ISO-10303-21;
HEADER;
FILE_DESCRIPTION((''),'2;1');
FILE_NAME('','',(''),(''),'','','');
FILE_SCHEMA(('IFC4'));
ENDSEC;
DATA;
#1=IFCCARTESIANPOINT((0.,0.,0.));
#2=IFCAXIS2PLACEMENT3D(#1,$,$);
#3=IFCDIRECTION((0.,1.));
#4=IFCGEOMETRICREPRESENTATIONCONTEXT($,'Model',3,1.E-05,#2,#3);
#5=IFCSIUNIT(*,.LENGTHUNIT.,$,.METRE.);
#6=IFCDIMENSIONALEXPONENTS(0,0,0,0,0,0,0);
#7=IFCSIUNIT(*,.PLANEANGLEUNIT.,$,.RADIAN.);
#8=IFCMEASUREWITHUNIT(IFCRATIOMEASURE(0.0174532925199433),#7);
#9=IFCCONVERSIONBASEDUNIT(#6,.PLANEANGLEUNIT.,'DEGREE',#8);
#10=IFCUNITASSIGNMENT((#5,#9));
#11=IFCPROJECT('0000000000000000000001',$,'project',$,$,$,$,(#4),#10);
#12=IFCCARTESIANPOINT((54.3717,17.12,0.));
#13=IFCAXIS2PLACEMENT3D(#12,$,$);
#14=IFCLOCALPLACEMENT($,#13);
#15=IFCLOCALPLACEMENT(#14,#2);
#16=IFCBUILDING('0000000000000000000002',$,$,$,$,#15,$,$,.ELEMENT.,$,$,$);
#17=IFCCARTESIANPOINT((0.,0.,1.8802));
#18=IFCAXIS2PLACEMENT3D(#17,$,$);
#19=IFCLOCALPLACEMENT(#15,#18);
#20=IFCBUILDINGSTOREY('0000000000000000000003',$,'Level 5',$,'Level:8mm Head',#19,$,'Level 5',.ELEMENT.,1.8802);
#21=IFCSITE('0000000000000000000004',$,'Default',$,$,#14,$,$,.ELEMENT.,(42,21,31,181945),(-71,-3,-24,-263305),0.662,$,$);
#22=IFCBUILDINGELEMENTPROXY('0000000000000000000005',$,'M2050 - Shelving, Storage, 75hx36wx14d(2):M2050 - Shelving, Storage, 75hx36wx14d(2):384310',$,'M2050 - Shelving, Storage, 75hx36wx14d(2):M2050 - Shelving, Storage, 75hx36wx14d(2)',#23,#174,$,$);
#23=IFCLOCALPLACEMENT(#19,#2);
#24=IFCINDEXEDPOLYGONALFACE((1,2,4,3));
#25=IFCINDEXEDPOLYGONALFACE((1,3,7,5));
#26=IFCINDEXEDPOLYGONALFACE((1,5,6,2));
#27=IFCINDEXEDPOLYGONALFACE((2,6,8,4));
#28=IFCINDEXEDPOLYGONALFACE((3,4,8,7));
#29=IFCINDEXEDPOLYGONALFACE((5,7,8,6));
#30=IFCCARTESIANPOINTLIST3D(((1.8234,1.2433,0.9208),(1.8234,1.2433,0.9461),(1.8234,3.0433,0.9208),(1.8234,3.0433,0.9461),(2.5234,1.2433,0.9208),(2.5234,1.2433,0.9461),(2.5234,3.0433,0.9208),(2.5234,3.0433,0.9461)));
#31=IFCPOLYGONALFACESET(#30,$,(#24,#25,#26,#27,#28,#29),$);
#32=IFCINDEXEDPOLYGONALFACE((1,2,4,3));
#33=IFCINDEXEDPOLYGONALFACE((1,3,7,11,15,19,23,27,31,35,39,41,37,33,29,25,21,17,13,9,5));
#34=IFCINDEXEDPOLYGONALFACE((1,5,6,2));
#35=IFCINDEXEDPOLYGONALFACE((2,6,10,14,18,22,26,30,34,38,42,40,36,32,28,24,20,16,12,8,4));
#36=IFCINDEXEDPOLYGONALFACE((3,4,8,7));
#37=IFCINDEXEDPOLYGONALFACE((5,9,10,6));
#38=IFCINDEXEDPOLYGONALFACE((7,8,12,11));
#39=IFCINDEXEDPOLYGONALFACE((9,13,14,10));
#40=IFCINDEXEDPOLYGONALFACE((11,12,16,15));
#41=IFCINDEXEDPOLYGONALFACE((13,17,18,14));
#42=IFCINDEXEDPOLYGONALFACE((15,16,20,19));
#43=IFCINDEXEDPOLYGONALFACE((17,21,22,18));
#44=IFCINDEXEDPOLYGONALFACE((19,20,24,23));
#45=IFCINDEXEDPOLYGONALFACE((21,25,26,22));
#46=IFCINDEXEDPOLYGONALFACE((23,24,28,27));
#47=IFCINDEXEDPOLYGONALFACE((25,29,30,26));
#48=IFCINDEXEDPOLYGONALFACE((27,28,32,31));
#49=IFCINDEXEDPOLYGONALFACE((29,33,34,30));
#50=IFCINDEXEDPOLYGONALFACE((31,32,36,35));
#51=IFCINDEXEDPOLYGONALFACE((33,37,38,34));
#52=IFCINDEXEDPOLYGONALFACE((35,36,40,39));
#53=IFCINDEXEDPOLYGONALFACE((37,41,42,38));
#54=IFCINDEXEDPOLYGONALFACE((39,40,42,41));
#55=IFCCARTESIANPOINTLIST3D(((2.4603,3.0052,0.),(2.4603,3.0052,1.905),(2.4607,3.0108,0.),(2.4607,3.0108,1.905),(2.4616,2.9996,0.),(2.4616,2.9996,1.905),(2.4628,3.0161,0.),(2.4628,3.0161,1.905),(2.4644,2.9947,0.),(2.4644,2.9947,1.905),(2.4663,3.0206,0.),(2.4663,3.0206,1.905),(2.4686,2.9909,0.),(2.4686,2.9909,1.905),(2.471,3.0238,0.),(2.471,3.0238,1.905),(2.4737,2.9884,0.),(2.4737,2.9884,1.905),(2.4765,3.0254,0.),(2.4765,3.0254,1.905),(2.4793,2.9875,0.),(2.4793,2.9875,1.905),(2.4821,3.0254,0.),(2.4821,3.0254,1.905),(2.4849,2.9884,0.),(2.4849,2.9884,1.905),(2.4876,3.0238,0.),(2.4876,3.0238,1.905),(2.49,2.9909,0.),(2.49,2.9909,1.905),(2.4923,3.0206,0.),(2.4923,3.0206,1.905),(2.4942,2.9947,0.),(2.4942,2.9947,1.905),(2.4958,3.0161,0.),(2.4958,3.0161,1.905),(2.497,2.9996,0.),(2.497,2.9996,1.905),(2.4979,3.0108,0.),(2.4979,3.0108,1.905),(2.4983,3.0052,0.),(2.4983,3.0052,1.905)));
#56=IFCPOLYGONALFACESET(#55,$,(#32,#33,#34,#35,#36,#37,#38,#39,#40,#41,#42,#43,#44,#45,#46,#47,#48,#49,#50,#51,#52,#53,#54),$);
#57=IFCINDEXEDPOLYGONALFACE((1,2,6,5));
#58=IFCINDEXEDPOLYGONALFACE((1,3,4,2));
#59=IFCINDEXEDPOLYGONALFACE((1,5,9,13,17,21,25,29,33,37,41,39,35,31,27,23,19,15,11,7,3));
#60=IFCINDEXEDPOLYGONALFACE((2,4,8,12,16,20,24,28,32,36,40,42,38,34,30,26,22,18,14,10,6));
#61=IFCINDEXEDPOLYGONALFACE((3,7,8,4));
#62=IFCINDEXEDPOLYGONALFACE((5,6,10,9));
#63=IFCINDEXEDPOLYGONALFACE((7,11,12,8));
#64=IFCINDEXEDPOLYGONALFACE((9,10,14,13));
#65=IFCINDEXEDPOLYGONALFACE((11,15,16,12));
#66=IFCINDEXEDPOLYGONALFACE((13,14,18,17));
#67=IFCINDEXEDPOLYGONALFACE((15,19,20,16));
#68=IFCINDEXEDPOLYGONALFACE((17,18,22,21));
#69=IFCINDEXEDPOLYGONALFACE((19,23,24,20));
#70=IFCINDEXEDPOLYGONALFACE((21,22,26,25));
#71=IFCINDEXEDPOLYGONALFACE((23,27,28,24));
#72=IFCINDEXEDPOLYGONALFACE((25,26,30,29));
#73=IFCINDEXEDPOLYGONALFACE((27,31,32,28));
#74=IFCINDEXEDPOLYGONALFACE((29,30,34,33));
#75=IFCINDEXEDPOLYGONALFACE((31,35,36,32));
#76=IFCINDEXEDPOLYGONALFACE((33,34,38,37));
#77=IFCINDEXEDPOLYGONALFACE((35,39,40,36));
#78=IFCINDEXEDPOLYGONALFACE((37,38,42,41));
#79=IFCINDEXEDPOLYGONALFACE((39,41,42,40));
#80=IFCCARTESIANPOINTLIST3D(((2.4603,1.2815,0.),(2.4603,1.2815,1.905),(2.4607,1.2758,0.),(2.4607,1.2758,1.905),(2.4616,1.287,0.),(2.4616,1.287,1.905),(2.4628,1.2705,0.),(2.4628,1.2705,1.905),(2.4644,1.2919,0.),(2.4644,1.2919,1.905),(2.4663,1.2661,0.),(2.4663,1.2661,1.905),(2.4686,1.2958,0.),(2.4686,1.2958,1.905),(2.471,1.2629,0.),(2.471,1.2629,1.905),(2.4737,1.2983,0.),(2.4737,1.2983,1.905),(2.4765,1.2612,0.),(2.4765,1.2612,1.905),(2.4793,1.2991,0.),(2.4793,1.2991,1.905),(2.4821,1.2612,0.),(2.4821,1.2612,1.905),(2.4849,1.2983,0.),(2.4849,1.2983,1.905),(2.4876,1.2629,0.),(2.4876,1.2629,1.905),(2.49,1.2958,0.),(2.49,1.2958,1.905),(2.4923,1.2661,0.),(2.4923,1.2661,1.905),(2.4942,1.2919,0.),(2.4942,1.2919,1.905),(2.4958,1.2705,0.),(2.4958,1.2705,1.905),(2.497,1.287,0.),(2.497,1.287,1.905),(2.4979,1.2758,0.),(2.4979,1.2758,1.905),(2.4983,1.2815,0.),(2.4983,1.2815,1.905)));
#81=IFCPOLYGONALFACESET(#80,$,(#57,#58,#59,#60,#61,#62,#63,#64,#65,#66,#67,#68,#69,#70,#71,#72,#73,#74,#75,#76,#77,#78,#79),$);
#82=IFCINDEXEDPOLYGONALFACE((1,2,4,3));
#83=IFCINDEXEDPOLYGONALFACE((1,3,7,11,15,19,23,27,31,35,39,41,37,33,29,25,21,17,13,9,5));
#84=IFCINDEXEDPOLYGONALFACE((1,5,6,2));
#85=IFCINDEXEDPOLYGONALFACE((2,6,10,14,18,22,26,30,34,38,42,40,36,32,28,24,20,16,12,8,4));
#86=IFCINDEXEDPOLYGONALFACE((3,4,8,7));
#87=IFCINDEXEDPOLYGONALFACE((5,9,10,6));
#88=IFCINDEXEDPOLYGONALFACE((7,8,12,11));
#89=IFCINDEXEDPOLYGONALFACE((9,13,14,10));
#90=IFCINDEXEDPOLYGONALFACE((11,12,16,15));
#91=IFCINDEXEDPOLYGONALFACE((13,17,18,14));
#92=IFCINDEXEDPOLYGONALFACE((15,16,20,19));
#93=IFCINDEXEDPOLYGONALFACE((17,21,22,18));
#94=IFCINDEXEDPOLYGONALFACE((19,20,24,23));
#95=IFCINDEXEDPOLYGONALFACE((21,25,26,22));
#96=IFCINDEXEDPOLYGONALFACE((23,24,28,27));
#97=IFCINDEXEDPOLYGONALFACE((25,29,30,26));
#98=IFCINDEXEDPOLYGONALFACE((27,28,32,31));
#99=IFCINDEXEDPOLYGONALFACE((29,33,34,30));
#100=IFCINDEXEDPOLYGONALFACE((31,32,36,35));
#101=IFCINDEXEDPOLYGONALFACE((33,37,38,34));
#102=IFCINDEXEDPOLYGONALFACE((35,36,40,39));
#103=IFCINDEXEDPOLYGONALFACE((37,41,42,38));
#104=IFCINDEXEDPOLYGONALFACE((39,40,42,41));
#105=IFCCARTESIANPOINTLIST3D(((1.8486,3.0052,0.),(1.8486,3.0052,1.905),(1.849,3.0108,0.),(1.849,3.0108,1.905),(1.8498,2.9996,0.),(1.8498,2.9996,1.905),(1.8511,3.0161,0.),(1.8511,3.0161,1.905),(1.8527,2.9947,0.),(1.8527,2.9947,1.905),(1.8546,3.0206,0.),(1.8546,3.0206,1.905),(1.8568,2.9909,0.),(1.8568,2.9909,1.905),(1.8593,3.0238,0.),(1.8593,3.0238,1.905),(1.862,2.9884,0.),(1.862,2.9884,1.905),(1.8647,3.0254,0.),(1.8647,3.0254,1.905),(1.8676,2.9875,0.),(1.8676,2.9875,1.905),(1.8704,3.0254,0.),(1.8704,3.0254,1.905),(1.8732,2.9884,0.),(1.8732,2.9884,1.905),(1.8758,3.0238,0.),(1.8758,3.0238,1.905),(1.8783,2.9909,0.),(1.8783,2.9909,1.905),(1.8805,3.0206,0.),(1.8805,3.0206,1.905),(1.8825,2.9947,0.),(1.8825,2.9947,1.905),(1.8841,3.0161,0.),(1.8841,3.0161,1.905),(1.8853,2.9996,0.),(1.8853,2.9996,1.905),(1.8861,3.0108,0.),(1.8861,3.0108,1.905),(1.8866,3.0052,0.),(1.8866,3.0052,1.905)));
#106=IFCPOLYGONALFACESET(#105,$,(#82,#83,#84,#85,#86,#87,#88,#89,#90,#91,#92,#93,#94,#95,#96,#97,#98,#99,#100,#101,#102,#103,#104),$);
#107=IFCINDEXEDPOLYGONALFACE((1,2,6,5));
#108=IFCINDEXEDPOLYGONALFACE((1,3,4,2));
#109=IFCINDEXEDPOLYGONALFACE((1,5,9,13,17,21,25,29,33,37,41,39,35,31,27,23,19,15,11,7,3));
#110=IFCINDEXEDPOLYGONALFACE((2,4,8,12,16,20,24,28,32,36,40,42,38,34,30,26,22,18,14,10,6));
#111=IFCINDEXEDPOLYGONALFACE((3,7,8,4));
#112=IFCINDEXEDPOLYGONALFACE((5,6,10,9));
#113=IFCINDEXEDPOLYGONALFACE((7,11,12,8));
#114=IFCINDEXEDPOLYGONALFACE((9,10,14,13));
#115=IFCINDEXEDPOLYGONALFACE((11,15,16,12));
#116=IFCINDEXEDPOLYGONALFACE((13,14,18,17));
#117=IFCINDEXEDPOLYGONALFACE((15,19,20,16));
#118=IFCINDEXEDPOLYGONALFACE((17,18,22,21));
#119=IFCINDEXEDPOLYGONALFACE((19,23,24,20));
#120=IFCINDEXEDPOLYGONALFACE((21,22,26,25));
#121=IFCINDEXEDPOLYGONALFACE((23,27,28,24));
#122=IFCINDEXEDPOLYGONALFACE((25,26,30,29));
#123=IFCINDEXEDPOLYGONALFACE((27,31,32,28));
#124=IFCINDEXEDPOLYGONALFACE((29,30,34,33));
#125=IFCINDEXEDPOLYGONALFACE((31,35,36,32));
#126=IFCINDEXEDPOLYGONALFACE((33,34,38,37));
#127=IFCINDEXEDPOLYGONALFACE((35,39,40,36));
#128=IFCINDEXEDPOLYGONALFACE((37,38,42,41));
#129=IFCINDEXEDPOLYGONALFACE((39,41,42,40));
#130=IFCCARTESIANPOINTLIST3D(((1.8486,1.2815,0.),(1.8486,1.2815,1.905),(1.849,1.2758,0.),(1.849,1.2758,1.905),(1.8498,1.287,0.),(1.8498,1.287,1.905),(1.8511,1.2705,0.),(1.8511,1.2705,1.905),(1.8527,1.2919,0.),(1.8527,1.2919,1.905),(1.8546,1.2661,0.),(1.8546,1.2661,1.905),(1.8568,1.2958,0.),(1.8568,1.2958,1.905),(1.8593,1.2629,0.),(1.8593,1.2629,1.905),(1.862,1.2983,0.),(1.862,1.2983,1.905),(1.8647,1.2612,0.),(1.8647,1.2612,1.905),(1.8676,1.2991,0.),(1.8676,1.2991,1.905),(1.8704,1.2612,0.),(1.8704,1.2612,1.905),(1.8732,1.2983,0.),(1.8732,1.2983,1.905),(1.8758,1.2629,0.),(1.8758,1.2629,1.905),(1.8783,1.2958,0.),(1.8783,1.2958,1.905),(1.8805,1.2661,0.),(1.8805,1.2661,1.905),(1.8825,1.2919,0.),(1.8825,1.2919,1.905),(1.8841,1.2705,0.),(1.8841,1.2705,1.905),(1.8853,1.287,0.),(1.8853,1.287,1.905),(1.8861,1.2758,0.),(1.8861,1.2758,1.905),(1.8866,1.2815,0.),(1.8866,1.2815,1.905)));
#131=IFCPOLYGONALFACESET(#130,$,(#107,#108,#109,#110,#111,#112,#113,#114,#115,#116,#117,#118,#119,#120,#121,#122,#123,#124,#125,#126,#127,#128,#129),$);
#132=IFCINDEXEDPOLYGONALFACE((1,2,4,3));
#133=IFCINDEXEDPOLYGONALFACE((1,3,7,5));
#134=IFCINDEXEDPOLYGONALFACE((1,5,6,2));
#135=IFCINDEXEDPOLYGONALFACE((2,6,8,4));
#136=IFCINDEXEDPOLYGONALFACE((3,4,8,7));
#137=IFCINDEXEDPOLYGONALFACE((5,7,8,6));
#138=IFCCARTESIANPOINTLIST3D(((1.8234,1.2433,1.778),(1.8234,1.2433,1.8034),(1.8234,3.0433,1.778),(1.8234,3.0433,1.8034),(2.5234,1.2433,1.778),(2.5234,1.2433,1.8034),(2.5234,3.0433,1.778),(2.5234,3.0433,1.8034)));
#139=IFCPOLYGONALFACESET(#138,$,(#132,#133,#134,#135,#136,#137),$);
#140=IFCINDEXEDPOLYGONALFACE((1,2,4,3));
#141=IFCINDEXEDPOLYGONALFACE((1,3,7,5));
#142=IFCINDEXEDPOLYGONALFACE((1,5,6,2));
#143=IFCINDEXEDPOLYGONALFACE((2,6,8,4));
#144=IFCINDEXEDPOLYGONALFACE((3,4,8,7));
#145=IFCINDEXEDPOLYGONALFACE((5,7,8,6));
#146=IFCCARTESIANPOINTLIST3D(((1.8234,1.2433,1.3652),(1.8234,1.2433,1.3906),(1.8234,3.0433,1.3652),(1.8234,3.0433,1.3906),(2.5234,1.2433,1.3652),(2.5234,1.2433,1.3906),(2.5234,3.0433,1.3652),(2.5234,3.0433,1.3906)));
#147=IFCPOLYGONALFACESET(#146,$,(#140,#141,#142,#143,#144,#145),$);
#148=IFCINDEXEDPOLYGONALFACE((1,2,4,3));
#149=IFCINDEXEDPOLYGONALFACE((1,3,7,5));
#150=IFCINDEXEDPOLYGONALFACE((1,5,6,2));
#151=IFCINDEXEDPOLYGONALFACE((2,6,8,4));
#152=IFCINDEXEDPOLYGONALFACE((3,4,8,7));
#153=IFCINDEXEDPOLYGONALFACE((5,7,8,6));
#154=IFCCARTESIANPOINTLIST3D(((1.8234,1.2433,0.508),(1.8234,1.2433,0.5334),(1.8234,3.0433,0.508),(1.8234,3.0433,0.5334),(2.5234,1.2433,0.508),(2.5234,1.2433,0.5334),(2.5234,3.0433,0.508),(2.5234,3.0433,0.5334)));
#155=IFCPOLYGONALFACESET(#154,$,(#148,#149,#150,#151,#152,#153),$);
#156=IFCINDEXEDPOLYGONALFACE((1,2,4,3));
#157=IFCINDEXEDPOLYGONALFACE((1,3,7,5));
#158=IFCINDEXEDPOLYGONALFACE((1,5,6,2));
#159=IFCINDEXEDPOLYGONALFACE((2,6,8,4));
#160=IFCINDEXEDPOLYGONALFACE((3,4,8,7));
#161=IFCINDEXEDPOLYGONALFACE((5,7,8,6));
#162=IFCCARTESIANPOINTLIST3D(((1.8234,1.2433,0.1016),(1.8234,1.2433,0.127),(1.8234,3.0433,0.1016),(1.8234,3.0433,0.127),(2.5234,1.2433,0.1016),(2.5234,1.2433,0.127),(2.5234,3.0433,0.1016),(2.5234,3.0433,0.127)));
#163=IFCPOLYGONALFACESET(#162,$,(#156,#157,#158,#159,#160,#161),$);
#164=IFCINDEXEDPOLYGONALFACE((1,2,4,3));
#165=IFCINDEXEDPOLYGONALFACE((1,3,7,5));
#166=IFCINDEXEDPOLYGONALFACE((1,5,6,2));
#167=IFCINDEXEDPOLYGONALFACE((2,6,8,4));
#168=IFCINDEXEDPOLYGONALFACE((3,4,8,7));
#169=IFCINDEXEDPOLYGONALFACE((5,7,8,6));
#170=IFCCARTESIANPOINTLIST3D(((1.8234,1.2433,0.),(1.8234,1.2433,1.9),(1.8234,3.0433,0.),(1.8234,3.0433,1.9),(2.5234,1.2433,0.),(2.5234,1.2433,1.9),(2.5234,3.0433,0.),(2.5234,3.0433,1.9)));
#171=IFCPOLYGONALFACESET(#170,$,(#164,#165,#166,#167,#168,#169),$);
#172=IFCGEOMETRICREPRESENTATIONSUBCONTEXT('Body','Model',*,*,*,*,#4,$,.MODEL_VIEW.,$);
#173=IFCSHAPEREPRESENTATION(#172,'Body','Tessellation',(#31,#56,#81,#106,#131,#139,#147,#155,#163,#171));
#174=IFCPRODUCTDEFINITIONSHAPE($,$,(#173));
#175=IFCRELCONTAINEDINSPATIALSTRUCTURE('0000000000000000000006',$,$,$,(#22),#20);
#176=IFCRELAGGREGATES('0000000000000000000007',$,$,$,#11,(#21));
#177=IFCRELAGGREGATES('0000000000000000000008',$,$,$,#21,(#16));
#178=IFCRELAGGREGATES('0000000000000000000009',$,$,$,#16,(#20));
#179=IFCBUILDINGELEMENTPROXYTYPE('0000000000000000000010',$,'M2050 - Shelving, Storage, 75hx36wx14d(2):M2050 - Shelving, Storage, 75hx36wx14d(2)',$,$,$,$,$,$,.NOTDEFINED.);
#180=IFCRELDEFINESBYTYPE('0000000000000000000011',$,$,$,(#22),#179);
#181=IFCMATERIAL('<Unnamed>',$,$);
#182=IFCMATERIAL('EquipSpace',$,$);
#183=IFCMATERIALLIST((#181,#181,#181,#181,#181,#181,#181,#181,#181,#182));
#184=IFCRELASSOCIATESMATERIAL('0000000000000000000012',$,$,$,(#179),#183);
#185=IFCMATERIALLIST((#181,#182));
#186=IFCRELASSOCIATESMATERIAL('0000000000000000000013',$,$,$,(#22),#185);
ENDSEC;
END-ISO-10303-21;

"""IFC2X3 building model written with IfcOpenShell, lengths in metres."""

from ifc_helpers import new_model, entity, si_unit, converted_unit, direction, frame, frame_2d, origin, origin_2d_with_axis, place, context, subcontext, project, spatial, rectangle, circle, extrude, source, transform, mapped, material, material_list, type_object, type_shapes, element, save


model = new_model("IFC2X3")

# Units and contexts
model_context = context("Model", 3, precision=1e-05, world=origin(), true_north=direction((0.0, 1.0)))
body_context = subcontext(model_context, "Body", "Model", "MODEL_VIEW")
ifc_project = project(units=[si_unit("LENGTHUNIT", "METRE"), converted_unit("PLANEANGLEUNIT", "DEGREE", entity("IfcRatioMeasure", 0.0174532925199433), si_unit("PLANEANGLEUNIT", "RADIAN"), dimensions=[0, 0, 0, 0, 0, 0, 0])], contexts=[model_context])

# Site, building, storey
site_placement = place(None, frame((54.3717, 17.12, 0.0)))
site = spatial("IfcSite", under=ifc_project, at=site_placement, Name="Default", CompositionType="ELEMENT", RefLatitude=(42, 21, 31, 181945), RefLongitude=(-71, -3, -24, -263305), RefElevation=0.662)
building_placement = place(site_placement, origin())
building = spatial("IfcBuilding", under=site, at=building_placement, CompositionType="ELEMENT")
storey_placement = place(building_placement, frame((0.0, 0.0, 1.8802)))
storey = spatial("IfcBuildingStorey", under=building, at=storey_placement, Name="Level 5", ObjectType="Level:8mm Head", LongName="Level 5", CompositionType="ELEMENT", Elevation=1.8802)

# Building element proxy
ifc_material_1 = material(Name="<Unnamed>")
ifc_material_2 = material(Name="EquipSpace")
ifc_material_list_1 = material_list([ifc_material_1, ifc_material_1, ifc_material_1, ifc_material_1, ifc_material_1, ifc_material_1, ifc_material_1, ifc_material_1, ifc_material_1, ifc_material_2])
building_element_proxy_type = type_object("IfcBuildingElementProxyType", Name="M2050 - Shelving, Storage, 75hx36wx14d(2):M2050 - Shelving, Storage, 75hx36wx14d(2)", PredefinedType="NOTDEFINED", material=ifc_material_list_1)
shared_shape = source(origin(), body_context, "Body", "SweptSolid", [
    extrude(rectangle(XDim=1.8, YDim=0.7, at=origin_2d_with_axis()), frame((0.0, 0.0, 0.9207), z_axis=(0.0, 0.0, 1.0), x_axis=(-1.0, 0.0, 0.0)), (0.0, 0.0, 1.0), 0.0254),
    extrude(circle(Radius=0.0191, at=origin_2d_with_axis()), frame((0.8633, -0.3059, 0.0), z_axis=(0.0, 0.0, 1.0), x_axis=(-1.0, 0.0, 0.0)), (0.0, 0.0, 1.0), 1.905),
    extrude(circle(Radius=0.0191, at=origin_2d_with_axis()), frame((-0.8633, -0.3059, 0.0)), (0.0, 0.0, 1.0), 1.905),
    extrude(circle(Radius=0.0191, at=origin_2d_with_axis()), frame((0.8633, 0.3059, 0.0), z_axis=(0.0, 0.0, 1.0), x_axis=(-1.0, 0.0, 0.0)), (0.0, 0.0, 1.0), 1.905),
    extrude(circle(Radius=0.0191, at=origin_2d_with_axis()), frame((-0.8633, 0.3059, 0.0)), (0.0, 0.0, 1.0), 1.905),
    extrude(rectangle(XDim=1.8, YDim=0.7, at=origin_2d_with_axis()), frame((0.0, 0.0, 1.778), z_axis=(0.0, 0.0, 1.0), x_axis=(-1.0, 0.0, 0.0)), (0.0, 0.0, 1.0), 0.0254),
    extrude(rectangle(XDim=1.8, YDim=0.7, at=origin_2d_with_axis()), frame((0.0, 0.0, 1.3653), z_axis=(0.0, 0.0, 1.0), x_axis=(-1.0, 0.0, 0.0)), (0.0, 0.0, 1.0), 0.0254),
    extrude(rectangle(XDim=1.8, YDim=0.7, at=origin_2d_with_axis()), frame((0.0, 0.0, 0.508), z_axis=(0.0, 0.0, 1.0), x_axis=(-1.0, 0.0, 0.0)), (0.0, 0.0, 1.0), 0.0254),
    extrude(rectangle(XDim=1.8, YDim=0.7, at=origin_2d_with_axis()), frame((0.0, 0.0, 0.1016), z_axis=(0.0, 0.0, 1.0), x_axis=(-1.0, 0.0, 0.0)), (0.0, 0.0, 1.0), 0.0254),
    extrude(rectangle(XDim=0.7, YDim=1.8, at=frame_2d((0.0, 0.18), x_axis=(1.0, 0.0))), frame((-0.18, 0.0, 0.0), z_axis=(0.0, 0.0, 1.0), x_axis=(0.0, -1.0, 0.0)), (0.0, 0.0, 1.0), 1.9),
])
type_shapes(building_element_proxy_type, [shared_shape])
ifc_material_list_2 = material_list([ifc_material_1, ifc_material_2])
proxy_1_placement = place(storey_placement, frame((2.1734, 2.1433, 0.0), z_axis=(0.0, 0.0, 1.0), x_axis=(0.0, 1.0, 0.0)))
element("IfcBuildingElementProxy", 1, at=proxy_1_placement, inside=storey, type_object=building_element_proxy_type, material=ifc_material_list_2, Name="M2050 - Shelving, Storage, 75hx36wx14d(2):M2050 - Shelving, Storage, 75hx36wx14d(2):384310", ObjectType="M2050 - Shelving, Storage, 75hx36wx14d(2):M2050 - Shelving, Storage, 75hx36wx14d(2)", context=body_context, shape_type="MappedRepresentation", body=[
    mapped(shared_shape, transform((0.0, 0.0, 0.0), scale=1.0)),
])

save(model, "model.ifc")
